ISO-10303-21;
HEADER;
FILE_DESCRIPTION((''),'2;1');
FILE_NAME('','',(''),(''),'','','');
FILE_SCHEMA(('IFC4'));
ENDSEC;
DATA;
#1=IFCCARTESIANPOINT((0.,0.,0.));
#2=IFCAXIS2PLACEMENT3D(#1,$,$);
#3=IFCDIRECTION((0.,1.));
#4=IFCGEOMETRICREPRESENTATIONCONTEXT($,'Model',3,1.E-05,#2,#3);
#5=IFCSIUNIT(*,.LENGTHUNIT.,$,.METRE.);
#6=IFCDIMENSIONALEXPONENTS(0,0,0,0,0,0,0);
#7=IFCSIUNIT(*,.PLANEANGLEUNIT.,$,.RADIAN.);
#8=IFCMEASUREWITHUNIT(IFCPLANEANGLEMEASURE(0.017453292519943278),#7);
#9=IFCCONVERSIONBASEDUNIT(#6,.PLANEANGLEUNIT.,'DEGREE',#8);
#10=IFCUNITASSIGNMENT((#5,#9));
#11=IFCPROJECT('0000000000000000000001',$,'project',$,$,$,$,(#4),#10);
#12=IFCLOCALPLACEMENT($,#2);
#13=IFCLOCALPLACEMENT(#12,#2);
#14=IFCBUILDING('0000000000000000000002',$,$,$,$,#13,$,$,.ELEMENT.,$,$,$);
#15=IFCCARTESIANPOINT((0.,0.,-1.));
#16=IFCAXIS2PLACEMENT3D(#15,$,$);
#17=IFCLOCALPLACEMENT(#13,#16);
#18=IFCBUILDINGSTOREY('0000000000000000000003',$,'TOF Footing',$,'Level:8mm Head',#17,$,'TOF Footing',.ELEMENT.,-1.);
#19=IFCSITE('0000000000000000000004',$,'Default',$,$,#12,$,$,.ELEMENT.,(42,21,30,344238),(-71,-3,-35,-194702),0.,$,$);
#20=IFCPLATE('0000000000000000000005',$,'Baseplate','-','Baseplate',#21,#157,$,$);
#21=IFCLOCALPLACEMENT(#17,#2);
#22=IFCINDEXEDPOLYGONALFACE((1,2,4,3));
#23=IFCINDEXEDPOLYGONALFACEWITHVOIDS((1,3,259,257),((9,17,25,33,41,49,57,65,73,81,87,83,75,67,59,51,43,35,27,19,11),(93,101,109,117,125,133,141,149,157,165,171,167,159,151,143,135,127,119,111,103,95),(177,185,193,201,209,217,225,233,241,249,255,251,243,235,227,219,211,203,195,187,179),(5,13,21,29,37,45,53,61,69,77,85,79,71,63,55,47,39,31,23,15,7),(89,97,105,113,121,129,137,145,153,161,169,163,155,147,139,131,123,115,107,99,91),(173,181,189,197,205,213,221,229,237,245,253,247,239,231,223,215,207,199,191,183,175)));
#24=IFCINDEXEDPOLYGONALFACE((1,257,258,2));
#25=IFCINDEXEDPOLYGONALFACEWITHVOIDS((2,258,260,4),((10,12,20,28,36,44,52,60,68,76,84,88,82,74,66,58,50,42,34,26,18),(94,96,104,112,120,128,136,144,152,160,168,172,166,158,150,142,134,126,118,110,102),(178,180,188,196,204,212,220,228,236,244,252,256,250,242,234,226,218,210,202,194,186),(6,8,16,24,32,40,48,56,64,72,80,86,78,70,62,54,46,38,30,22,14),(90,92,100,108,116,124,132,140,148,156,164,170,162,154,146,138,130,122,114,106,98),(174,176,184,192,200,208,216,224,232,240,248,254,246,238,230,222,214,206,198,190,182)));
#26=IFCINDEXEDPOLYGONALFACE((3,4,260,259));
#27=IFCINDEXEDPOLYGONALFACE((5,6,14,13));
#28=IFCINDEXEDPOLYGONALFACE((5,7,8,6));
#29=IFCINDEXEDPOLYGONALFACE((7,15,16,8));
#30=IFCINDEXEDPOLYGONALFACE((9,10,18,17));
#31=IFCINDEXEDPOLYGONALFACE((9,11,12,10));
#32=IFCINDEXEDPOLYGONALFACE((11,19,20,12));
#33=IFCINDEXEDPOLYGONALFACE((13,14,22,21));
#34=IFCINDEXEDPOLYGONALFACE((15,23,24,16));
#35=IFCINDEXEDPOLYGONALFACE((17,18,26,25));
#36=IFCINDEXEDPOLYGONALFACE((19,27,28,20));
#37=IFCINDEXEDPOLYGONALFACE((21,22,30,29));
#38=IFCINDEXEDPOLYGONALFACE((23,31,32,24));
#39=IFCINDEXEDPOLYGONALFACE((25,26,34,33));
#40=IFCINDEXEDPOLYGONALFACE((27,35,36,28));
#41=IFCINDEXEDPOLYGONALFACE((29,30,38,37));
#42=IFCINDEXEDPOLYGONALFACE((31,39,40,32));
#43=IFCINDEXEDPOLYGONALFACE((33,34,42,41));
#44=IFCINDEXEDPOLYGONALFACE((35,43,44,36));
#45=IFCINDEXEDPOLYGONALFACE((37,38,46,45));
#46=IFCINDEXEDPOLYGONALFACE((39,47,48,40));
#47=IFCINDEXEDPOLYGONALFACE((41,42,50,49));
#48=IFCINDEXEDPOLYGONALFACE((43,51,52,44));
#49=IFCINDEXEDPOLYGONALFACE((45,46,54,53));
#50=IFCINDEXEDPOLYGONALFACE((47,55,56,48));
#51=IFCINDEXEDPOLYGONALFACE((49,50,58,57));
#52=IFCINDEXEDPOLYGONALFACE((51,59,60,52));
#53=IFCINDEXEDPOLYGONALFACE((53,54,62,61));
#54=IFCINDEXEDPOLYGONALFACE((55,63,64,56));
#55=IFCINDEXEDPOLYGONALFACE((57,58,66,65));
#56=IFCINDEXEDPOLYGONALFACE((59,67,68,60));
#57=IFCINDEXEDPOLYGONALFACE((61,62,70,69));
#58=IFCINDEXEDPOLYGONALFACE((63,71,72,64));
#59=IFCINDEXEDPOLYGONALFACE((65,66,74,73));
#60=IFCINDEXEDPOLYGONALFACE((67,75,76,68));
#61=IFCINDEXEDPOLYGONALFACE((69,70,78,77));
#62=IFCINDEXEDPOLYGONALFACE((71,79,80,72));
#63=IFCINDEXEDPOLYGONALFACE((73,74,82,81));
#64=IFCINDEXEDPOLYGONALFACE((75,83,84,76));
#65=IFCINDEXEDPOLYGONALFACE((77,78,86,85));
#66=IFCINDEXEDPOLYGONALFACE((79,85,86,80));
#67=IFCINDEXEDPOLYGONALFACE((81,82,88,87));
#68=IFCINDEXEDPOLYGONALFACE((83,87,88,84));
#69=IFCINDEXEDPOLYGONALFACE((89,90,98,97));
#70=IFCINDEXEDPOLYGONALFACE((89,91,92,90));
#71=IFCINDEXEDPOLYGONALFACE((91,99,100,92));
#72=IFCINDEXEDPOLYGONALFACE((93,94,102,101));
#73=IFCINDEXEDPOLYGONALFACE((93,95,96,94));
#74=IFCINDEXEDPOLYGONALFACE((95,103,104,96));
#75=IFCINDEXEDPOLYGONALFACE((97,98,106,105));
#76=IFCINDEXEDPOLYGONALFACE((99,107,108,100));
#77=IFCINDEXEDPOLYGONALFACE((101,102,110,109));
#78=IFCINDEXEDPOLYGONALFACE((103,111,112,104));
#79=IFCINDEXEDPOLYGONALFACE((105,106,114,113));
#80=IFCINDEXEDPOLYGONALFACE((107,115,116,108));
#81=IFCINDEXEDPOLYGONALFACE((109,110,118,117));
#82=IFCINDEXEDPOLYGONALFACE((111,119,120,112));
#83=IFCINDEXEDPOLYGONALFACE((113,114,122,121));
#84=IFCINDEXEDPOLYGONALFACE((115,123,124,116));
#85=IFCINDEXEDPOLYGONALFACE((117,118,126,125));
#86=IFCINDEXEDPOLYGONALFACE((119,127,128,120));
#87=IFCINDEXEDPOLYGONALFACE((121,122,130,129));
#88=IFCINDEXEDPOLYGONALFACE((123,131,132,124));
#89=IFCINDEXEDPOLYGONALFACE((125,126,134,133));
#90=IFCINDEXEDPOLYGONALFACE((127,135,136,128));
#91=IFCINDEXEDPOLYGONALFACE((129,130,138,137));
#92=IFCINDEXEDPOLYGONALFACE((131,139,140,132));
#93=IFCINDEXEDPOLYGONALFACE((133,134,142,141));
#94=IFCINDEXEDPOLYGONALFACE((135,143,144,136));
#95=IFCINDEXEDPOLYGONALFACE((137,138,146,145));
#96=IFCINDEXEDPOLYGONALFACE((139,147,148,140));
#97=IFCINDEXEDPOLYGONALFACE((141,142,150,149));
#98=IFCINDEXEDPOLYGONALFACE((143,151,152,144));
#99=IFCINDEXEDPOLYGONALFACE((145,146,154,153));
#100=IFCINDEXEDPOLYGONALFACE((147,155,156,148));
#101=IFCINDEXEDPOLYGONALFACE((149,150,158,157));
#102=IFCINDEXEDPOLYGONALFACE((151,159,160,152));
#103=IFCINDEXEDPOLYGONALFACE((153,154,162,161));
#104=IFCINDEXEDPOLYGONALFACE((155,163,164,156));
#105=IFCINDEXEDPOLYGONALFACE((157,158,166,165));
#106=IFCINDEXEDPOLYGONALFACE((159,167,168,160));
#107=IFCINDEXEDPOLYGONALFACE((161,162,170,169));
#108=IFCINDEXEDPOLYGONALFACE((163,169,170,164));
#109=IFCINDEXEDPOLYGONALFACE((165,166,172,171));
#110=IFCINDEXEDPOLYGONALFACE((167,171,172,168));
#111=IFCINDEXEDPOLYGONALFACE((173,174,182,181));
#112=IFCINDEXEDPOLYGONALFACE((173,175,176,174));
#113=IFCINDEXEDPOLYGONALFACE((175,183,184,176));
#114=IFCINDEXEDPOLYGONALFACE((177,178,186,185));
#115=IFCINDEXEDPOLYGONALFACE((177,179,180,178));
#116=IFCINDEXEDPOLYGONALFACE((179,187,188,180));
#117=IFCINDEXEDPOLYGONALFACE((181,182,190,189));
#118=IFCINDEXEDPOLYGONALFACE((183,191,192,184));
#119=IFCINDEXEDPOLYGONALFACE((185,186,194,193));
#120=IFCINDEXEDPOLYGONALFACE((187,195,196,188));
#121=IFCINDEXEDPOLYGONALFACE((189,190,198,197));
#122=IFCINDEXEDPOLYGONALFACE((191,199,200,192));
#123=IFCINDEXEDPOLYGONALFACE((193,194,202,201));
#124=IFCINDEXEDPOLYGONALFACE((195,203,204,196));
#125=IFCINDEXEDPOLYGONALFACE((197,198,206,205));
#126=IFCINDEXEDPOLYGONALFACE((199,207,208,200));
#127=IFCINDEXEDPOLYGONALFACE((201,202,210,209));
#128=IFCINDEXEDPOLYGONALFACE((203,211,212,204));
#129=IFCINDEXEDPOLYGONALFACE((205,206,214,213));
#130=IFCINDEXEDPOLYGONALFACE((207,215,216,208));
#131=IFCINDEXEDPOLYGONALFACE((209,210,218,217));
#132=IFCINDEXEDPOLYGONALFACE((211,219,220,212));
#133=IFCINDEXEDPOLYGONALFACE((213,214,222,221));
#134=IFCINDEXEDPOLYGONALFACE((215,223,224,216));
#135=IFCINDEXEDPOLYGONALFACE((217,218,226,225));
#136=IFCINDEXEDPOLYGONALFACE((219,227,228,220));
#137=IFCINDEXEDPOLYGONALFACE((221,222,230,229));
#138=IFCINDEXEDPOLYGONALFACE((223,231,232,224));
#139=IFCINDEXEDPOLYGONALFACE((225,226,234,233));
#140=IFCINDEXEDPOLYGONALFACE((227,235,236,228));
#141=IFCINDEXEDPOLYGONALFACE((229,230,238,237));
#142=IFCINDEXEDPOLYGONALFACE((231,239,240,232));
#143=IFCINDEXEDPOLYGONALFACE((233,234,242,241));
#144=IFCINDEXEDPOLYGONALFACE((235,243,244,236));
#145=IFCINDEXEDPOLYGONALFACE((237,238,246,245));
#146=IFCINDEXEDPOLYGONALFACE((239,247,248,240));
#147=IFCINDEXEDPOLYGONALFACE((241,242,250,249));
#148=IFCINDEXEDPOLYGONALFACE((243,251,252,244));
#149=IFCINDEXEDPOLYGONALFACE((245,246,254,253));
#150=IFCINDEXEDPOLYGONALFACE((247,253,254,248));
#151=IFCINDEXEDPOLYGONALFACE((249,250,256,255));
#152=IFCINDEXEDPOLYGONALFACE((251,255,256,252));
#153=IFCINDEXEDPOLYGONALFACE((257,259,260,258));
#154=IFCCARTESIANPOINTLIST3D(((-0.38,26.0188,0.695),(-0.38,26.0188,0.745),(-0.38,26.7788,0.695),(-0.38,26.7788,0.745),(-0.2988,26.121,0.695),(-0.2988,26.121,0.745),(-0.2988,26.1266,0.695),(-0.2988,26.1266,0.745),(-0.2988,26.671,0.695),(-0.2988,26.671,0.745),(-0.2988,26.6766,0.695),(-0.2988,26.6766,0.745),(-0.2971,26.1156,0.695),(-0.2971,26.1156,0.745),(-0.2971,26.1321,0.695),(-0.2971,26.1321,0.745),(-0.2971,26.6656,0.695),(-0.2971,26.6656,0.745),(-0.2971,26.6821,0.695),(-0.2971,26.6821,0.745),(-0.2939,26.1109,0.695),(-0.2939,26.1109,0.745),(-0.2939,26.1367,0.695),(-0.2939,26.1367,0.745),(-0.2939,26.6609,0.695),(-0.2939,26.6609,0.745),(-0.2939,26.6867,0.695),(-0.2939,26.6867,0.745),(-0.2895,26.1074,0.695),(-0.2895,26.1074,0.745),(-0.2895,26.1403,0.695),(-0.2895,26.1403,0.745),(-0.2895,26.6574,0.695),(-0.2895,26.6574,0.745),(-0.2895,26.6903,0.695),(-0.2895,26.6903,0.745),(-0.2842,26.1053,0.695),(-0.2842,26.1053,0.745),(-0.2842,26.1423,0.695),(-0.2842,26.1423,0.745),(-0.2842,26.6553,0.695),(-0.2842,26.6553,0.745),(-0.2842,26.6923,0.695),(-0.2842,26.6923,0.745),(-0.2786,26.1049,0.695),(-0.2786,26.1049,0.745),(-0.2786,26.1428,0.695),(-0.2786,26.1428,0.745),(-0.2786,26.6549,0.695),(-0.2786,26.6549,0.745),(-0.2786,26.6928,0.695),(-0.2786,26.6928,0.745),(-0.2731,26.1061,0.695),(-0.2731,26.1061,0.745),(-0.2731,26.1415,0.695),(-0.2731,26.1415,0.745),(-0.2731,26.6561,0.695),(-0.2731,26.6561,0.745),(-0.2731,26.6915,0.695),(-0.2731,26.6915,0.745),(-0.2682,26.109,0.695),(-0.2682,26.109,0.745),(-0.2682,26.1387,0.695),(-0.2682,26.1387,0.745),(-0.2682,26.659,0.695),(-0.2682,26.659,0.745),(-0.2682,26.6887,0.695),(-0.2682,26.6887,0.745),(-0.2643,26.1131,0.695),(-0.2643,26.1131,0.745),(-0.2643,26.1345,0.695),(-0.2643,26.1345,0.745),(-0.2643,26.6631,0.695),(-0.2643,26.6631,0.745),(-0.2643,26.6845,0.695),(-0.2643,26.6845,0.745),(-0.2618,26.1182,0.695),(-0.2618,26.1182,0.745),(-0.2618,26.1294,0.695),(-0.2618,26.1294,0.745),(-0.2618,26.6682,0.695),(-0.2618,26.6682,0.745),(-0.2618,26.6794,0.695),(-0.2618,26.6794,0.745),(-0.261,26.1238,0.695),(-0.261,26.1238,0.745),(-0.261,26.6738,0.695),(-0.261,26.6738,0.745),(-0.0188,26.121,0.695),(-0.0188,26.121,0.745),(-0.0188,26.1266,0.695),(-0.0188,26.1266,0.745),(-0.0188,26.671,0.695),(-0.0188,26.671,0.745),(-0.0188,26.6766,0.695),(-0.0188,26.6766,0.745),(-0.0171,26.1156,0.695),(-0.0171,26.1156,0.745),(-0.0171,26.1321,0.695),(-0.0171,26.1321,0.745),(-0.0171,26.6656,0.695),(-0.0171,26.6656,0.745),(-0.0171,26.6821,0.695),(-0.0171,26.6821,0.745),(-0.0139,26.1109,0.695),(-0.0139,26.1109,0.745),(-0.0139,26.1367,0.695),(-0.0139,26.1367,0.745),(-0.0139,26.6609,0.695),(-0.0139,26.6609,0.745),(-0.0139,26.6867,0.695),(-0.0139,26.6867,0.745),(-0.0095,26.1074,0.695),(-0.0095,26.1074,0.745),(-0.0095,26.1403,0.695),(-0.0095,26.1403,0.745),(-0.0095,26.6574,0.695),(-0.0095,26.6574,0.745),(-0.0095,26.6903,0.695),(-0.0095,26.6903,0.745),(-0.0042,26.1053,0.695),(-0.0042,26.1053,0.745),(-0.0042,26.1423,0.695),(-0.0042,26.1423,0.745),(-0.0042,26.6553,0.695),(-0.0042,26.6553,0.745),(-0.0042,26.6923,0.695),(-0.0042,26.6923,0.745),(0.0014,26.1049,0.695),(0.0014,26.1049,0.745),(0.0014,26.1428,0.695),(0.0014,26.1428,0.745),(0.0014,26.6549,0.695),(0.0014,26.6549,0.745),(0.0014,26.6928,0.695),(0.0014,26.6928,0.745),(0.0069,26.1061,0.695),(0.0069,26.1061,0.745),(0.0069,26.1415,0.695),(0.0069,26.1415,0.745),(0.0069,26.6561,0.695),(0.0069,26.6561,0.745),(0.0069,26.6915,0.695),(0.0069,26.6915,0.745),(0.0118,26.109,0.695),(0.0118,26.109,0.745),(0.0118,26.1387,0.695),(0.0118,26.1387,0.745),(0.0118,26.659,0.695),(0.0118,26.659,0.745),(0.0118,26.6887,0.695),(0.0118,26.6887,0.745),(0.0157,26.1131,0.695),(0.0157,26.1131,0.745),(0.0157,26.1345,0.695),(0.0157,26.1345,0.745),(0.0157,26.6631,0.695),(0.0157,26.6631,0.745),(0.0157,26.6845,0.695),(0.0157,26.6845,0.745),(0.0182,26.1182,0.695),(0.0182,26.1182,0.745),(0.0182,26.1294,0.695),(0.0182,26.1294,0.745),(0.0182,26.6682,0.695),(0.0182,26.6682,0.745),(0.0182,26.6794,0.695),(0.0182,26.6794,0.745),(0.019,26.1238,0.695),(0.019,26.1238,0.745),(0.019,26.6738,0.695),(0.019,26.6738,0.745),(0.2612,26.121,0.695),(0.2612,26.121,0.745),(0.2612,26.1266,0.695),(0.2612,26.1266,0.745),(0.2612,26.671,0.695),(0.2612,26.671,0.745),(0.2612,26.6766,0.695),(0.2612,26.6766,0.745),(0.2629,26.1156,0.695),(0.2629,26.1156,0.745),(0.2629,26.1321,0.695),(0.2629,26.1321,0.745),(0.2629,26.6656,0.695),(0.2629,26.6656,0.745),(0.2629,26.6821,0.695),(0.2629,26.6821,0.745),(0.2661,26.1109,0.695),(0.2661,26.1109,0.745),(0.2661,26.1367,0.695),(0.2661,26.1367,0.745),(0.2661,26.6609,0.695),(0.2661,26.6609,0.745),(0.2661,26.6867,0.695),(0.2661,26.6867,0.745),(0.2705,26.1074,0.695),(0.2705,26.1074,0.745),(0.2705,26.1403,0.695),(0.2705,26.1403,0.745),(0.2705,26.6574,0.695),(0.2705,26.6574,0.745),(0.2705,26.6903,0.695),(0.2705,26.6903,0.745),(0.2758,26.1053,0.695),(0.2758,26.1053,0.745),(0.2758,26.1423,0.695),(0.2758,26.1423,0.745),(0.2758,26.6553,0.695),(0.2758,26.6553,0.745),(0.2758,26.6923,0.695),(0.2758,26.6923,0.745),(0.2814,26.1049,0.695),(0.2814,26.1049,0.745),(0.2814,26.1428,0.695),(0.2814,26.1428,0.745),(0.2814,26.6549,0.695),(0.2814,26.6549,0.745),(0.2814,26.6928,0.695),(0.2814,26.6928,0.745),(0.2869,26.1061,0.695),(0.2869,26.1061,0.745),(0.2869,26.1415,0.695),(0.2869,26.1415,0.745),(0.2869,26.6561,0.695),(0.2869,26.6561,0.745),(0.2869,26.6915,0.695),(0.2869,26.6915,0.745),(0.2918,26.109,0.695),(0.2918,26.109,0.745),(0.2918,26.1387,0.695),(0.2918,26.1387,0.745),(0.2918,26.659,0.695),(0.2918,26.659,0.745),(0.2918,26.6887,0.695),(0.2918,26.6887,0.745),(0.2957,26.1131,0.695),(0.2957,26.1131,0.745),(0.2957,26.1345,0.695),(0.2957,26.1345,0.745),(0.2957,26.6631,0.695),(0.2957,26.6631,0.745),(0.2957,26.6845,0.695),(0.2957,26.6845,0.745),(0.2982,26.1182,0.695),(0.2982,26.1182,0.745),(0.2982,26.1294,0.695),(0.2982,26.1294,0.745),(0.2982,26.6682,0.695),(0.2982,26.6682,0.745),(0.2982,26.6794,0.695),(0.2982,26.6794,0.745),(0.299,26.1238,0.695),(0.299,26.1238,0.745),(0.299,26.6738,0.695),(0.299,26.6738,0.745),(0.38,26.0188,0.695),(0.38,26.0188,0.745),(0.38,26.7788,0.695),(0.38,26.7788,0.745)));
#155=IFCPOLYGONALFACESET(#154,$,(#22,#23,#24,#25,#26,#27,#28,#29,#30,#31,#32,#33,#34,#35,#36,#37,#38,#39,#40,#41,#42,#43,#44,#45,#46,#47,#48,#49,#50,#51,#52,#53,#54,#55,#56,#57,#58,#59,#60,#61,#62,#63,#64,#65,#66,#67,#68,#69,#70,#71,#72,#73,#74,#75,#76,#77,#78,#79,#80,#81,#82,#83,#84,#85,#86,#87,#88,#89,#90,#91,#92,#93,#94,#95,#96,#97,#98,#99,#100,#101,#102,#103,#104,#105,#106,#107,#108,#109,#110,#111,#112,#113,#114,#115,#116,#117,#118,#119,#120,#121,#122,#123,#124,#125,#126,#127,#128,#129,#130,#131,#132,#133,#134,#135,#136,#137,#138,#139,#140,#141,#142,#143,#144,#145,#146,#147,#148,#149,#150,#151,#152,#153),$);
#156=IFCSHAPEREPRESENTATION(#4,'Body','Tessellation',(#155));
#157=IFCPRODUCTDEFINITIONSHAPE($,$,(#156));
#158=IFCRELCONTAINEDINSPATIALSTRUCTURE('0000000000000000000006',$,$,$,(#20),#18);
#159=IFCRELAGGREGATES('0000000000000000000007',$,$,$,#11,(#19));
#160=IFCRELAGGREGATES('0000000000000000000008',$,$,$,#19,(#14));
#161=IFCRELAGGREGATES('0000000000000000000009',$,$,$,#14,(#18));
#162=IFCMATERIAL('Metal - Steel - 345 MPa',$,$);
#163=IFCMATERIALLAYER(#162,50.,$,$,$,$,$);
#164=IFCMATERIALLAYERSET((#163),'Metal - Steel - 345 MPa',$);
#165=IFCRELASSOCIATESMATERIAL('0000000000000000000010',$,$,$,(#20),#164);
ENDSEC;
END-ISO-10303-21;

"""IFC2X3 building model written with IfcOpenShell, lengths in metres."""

from ifc_helpers import new_model, entity, si_unit, converted_unit, direction, frame, frame_2d, origin, origin_with_axes, place, context, project, spatial, polyline, circle, outline, extrude, material, layer, layer_set, element, save


model = new_model("IFC2X3")

# Units and contexts
model_context = context("Model", 3, precision=1e-05, world=origin(), true_north=direction((0.0, 1.0)))
ifc_project = project(units=[si_unit("LENGTHUNIT", "METRE"), converted_unit("PLANEANGLEUNIT", "DEGREE", entity("IfcPlaneAngleMeasure", 0.017453292519943278), si_unit("PLANEANGLEUNIT", "RADIAN"), dimensions=[0, 0, 0, 0, 0, 0, 0])], contexts=[model_context])

# Site, building, storey
site_placement = place(None, origin())
site = spatial("IfcSite", under=ifc_project, at=site_placement, Name="Default", CompositionType="ELEMENT", RefLatitude=(42, 21, 30, 344238), RefLongitude=(-71, -3, -35, -194702), RefElevation=0.0)
building_placement = place(site_placement, origin())
building = spatial("IfcBuilding", under=site, at=building_placement, CompositionType="ELEMENT")
storey_placement = place(building_placement, frame((0.0, 0.0, -1.0)))
storey = spatial("IfcBuildingStorey", under=building, at=storey_placement, Name="TOF Footing", ObjectType="Level:8mm Head", LongName="TOF Footing", CompositionType="ELEMENT", Elevation=-1.0)

# Plate, openings
ifc_material_1 = material(Name="Metal - Steel - 345 MPa")
ifc_layer = layer(ifc_material_1, 50.0)
ifc_layer_set = layer_set([ifc_layer], Name="Metal - Steel - 345 MPa")
plate_1_placement = place(storey_placement, frame((-0.38, 26.7788, 0.745), z_axis=(0.0, 0.0, -1.0), x_axis=(1.0, 0.0, 0.0)))
plate_1 = element("IfcPlate", 1, at=plate_1_placement, inside=storey, material=ifc_layer_set, Name="Baseplate", Description="-", ObjectType="Baseplate", context=model_context, shape_type="SweptSolid", body=[
    extrude(outline(polyline([(0.0, 0.0), (0.76, 0.0), (0.76, 0.76), (0.0, 0.76), (0.0, 0.0)])), origin_with_axes(), (0.0, 0.0, 1.0), 0.05),
])
opening_1_placement = place(plate_1_placement, frame((0.38, 0.38, 0.0505), z_axis=(0.0, 0.0, -1.0), x_axis=(1.0, 0.0, 0.0)))
element("IfcOpeningElement", 2, at=opening_1_placement, cuts=plate_1, ObjectType="Opening", context=model_context, shape_type="SweptSolid", body=[
    extrude(circle(Radius=0.019, at=frame_2d((0.0, 0.275), x_axis=(1.0, 0.0))), origin(), (0.0, 0.0, 1.0), 0.051),
])
opening_2_placement = place(plate_1_placement, frame((0.38, 0.38, 0.0505), z_axis=(0.0, 0.0, -1.0), x_axis=(1.0, 0.0, 0.0)))
element("IfcOpeningElement", 3, at=opening_2_placement, cuts=plate_1, ObjectType="Opening", context=model_context, shape_type="SweptSolid", body=[
    extrude(circle(Radius=0.019, at=frame_2d((0.28, 0.275), x_axis=(1.0, 0.0))), origin(), (0.0, 0.0, 1.0), 0.051),
])
opening_3_placement = place(plate_1_placement, frame((0.38, 0.38, 0.0505), z_axis=(0.0, 0.0, -1.0), x_axis=(1.0, 0.0, 0.0)))
element("IfcOpeningElement", 4, at=opening_3_placement, cuts=plate_1, ObjectType="Opening", context=model_context, shape_type="SweptSolid", body=[
    extrude(circle(Radius=0.019, at=frame_2d((-0.28, 0.275), x_axis=(1.0, 0.0))), origin(), (0.0, 0.0, 1.0), 0.051),
])
opening_4_placement = place(plate_1_placement, frame((0.38, 0.38, 0.0505), z_axis=(0.0, 0.0, -1.0), x_axis=(1.0, 0.0, 0.0)))
element("IfcOpeningElement", 5, at=opening_4_placement, cuts=plate_1, ObjectType="Opening", context=model_context, shape_type="SweptSolid", body=[
    extrude(circle(Radius=0.019, at=frame_2d((0.0, -0.275), x_axis=(1.0, 0.0))), origin(), (0.0, 0.0, 1.0), 0.051),
])
opening_5_placement = place(plate_1_placement, frame((0.38, 0.38, 0.0505), z_axis=(0.0, 0.0, -1.0), x_axis=(1.0, 0.0, 0.0)))
element("IfcOpeningElement", 6, at=opening_5_placement, cuts=plate_1, ObjectType="Opening", context=model_context, shape_type="SweptSolid", body=[
    extrude(circle(Radius=0.019, at=frame_2d((0.28, -0.275), x_axis=(1.0, 0.0))), origin(), (0.0, 0.0, 1.0), 0.051),
])
opening_6_placement = place(plate_1_placement, frame((0.38, 0.38, 0.0505), z_axis=(0.0, 0.0, -1.0), x_axis=(1.0, 0.0, 0.0)))
element("IfcOpeningElement", 7, at=opening_6_placement, cuts=plate_1, ObjectType="Opening", context=model_context, shape_type="SweptSolid", body=[
    extrude(circle(Radius=0.019, at=frame_2d((-0.28, -0.275), x_axis=(1.0, 0.0))), origin(), (0.0, 0.0, 1.0), 0.051),
])

save(model, "model.ifc")
